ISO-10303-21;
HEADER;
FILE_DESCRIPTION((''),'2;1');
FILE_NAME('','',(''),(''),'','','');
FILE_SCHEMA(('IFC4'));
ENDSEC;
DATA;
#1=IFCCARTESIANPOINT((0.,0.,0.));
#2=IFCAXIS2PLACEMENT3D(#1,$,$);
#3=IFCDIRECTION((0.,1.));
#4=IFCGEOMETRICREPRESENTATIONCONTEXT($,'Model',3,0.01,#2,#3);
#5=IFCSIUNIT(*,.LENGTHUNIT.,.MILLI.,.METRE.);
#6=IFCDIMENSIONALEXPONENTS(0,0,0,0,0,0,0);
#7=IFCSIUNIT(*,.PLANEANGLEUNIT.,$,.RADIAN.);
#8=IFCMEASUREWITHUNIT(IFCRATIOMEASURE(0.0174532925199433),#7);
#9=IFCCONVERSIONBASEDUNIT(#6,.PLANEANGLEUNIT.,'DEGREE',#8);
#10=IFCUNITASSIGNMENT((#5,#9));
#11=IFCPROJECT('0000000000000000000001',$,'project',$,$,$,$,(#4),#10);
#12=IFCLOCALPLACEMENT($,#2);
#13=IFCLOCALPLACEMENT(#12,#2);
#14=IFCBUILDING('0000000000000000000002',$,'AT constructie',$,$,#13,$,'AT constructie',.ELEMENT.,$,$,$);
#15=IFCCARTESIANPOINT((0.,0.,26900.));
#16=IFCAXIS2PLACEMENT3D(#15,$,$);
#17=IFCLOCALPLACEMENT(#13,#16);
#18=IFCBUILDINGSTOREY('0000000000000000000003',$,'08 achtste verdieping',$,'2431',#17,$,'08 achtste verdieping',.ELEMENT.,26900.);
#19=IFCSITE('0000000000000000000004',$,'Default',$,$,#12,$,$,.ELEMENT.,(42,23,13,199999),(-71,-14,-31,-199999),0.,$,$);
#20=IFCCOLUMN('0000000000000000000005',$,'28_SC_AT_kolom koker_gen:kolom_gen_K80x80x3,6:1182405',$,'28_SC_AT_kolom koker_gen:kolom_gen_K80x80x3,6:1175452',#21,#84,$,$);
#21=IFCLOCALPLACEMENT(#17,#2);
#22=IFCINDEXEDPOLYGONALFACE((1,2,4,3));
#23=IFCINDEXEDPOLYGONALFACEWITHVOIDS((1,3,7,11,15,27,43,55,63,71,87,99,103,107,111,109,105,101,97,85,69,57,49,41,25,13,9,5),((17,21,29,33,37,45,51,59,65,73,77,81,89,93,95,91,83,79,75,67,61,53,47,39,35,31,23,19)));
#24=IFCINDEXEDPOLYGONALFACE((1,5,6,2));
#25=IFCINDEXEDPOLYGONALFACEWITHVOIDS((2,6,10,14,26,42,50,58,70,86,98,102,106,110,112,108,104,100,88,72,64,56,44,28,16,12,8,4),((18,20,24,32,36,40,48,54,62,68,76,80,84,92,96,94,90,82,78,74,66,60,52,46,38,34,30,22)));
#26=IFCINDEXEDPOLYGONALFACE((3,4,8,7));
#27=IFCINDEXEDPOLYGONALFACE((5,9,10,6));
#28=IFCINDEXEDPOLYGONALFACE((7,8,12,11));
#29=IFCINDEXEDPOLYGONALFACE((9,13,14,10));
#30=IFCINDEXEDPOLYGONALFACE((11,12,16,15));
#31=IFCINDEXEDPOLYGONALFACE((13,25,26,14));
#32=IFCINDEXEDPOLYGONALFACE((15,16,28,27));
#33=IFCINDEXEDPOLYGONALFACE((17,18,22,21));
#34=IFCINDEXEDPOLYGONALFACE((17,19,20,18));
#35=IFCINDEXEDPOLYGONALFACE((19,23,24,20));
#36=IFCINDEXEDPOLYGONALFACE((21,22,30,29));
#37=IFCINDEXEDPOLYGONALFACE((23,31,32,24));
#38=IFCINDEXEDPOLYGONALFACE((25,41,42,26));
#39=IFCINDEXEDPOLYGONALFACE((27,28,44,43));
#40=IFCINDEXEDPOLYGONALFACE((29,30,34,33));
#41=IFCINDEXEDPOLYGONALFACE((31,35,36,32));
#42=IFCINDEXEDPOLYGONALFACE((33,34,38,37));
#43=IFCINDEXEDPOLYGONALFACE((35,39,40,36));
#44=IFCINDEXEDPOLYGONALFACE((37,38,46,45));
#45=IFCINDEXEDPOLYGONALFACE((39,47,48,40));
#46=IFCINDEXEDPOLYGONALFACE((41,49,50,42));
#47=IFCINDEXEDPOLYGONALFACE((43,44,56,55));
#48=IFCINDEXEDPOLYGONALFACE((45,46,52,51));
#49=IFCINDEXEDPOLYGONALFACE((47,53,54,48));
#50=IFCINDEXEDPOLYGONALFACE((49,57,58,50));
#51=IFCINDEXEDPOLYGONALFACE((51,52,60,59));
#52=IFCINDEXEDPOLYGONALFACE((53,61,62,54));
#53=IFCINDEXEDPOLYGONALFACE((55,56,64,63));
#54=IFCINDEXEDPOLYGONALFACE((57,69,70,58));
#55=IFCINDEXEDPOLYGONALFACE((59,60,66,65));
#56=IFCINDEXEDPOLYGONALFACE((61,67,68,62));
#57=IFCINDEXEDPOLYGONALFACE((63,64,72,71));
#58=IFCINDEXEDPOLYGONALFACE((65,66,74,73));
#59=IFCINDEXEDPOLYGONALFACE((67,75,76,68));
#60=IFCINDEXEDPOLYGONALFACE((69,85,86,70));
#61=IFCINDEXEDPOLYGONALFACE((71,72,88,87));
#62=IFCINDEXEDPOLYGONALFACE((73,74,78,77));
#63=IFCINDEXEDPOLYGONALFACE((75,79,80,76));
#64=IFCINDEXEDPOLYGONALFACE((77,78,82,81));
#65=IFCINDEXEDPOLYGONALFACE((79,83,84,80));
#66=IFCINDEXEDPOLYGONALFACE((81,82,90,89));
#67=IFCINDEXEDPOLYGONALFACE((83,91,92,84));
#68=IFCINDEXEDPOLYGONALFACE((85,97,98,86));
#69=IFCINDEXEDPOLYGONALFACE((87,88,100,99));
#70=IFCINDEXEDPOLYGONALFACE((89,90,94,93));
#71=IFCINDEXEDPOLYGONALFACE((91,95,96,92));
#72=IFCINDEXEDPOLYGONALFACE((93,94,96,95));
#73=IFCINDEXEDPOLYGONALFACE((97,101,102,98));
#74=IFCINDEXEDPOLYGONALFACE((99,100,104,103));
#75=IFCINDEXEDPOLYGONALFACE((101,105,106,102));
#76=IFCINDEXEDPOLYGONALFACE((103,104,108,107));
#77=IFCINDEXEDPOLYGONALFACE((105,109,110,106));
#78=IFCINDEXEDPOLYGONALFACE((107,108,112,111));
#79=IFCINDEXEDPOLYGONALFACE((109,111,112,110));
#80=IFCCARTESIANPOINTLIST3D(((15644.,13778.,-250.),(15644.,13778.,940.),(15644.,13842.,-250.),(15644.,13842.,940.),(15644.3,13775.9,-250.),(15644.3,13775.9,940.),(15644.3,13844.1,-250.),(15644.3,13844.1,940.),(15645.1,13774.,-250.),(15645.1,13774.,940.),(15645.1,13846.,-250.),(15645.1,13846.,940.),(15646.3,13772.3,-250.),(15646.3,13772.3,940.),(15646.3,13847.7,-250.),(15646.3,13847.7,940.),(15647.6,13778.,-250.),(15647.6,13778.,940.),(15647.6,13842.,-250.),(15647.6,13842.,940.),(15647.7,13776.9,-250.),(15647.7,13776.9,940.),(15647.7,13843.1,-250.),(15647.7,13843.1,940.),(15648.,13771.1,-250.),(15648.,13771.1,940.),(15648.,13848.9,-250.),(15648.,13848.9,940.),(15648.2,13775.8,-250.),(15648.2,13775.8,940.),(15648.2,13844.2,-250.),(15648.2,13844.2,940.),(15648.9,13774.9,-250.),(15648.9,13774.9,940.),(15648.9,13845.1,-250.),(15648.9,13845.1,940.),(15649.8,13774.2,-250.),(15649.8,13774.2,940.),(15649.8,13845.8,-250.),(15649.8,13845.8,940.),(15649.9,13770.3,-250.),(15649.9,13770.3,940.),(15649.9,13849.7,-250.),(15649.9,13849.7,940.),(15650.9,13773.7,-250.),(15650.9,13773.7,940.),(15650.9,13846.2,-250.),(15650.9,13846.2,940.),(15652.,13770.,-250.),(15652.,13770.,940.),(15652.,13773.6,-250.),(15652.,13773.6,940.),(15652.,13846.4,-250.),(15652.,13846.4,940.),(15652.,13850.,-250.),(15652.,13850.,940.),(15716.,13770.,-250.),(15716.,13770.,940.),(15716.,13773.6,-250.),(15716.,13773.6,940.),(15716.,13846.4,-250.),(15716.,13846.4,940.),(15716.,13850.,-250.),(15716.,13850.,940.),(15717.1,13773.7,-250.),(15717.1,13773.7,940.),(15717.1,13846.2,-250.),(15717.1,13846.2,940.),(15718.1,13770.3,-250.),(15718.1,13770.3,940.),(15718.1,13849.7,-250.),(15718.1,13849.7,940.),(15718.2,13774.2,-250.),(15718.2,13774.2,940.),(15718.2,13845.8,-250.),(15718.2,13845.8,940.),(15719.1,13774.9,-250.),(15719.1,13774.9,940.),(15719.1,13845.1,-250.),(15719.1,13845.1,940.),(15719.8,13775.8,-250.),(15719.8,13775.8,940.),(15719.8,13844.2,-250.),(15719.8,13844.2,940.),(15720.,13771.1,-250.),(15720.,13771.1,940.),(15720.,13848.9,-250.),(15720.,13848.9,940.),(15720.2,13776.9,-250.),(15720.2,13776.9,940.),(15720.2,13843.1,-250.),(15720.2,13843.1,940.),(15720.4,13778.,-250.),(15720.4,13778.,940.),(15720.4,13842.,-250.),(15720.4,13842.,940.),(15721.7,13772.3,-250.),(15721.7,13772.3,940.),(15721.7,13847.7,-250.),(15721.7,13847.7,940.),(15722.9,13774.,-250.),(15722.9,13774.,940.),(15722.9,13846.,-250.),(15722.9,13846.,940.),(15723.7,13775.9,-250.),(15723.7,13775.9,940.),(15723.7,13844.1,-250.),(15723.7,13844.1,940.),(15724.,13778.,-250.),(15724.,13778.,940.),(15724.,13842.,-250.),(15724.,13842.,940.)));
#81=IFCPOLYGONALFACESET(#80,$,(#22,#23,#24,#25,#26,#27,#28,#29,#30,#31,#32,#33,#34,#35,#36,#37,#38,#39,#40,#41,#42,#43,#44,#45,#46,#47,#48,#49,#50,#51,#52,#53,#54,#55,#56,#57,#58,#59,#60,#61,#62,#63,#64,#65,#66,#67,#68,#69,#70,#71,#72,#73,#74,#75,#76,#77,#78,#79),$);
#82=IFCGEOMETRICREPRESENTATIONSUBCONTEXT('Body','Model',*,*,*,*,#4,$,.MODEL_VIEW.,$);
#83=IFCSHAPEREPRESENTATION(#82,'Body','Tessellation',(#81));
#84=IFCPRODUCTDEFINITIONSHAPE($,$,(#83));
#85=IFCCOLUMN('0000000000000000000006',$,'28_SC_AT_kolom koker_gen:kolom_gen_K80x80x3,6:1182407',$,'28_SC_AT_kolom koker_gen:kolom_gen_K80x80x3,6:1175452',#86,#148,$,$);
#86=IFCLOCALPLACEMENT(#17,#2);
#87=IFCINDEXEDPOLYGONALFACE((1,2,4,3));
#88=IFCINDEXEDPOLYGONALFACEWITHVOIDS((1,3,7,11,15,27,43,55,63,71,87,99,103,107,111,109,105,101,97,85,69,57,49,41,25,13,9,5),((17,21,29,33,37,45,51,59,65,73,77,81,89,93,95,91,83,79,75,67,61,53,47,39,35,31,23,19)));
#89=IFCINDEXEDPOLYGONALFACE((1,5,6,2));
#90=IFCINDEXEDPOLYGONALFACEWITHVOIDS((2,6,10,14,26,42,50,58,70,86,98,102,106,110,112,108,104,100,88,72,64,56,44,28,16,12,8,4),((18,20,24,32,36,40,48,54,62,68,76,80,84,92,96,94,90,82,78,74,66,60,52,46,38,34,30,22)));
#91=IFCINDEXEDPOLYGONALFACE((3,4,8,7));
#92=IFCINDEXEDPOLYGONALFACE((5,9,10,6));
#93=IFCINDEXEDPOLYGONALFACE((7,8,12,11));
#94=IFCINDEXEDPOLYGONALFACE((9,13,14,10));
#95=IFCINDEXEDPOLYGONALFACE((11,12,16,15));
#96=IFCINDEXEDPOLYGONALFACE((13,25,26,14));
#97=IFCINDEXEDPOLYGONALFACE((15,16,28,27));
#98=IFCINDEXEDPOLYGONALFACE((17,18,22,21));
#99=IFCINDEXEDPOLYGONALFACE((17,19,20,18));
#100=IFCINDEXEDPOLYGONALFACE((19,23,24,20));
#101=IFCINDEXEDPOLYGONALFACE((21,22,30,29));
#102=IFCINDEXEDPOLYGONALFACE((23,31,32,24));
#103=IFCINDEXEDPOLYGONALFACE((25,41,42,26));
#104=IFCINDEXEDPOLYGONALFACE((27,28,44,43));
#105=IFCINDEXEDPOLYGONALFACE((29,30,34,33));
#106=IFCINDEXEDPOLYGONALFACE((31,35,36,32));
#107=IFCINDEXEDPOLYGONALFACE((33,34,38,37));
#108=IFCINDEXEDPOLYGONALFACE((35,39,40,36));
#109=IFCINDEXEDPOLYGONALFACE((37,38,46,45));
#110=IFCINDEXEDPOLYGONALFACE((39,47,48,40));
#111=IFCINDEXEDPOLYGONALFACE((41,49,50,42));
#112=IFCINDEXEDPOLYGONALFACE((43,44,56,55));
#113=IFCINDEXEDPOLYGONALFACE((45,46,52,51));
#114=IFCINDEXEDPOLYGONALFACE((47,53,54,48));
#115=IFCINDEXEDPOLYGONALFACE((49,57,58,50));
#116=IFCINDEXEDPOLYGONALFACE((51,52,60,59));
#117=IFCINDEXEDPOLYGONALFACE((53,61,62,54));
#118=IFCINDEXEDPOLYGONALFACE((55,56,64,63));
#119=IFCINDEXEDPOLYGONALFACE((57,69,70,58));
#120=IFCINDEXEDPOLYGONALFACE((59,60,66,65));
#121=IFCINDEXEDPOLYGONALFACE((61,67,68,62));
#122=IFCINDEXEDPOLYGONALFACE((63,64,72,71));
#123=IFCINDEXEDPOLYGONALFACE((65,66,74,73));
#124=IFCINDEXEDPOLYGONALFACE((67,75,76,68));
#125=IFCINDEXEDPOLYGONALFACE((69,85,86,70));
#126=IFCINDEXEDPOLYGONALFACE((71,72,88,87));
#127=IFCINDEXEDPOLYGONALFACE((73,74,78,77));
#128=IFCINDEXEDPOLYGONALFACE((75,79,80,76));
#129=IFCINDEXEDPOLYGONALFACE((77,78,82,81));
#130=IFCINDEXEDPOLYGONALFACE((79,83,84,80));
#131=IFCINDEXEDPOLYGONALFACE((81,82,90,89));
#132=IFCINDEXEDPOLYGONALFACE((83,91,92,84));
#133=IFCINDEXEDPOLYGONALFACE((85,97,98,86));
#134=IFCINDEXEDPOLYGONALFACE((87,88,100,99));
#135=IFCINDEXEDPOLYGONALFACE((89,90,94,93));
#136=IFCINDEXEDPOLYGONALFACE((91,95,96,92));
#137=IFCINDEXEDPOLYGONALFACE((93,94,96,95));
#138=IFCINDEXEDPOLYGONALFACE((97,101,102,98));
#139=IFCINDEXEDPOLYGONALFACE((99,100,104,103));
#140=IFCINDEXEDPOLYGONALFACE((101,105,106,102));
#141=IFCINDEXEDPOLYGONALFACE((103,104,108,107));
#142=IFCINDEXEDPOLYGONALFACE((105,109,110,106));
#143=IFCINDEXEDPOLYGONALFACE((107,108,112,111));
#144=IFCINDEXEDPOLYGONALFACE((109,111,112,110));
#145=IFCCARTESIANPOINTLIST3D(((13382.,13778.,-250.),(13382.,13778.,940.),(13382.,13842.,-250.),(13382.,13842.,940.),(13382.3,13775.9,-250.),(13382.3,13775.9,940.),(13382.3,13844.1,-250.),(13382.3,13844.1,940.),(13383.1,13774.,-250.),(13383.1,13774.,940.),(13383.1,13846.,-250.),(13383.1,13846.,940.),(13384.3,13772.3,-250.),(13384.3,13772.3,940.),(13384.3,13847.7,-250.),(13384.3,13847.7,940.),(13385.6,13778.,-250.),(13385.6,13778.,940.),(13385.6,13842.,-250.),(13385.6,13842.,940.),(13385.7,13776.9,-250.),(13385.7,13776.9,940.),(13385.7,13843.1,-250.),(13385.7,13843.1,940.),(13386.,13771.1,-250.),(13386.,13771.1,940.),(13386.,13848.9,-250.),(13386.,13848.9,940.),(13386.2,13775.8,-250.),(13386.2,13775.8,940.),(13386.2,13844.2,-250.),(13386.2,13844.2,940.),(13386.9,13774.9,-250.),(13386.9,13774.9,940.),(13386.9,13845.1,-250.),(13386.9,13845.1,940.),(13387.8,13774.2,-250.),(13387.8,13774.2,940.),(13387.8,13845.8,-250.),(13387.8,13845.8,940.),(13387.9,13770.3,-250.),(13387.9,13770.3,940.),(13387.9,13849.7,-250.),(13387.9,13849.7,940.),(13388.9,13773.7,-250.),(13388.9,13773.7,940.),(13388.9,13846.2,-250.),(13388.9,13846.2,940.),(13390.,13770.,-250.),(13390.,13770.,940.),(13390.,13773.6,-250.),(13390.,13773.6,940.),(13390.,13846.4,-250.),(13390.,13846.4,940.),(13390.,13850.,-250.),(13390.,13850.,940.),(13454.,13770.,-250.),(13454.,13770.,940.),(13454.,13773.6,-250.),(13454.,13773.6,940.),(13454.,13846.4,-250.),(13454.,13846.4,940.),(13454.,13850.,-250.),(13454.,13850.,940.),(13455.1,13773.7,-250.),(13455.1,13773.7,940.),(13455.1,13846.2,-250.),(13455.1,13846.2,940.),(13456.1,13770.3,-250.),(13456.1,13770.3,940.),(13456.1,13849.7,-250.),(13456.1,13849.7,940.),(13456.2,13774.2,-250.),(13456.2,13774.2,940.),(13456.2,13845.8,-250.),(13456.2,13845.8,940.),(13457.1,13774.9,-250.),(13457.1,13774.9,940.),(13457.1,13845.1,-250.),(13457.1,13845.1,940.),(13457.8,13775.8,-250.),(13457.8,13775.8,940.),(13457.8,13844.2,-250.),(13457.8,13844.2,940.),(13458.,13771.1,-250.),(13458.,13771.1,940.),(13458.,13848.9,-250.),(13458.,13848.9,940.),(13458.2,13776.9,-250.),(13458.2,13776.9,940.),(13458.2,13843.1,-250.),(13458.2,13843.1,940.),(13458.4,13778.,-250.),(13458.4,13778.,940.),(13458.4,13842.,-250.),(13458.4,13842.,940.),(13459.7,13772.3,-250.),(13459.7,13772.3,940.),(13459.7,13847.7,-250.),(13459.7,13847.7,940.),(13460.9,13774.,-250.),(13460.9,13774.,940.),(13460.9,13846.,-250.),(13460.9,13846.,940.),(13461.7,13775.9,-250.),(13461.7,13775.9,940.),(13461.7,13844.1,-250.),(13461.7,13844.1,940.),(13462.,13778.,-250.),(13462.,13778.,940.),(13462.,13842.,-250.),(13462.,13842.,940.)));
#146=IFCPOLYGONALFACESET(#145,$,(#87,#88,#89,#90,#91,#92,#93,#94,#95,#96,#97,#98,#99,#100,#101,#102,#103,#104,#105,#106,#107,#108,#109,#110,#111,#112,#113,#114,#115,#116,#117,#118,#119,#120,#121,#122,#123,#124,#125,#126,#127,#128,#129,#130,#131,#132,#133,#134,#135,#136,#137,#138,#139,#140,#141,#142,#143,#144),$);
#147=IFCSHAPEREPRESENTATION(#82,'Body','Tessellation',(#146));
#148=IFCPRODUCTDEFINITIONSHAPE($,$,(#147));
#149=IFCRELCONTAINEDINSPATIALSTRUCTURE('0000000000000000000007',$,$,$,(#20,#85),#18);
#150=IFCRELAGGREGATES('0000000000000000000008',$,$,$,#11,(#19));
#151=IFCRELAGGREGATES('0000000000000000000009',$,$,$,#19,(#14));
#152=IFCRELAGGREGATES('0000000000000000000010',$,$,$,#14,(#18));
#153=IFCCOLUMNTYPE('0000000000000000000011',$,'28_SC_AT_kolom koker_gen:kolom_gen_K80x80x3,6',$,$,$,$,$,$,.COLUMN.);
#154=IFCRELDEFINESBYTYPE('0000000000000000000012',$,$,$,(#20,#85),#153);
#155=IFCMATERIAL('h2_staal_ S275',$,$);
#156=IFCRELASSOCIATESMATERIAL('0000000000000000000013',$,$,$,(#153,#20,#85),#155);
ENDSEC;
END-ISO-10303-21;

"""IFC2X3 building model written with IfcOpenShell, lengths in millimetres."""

from ifc_helpers import new_model, entity, si_unit, converted_unit, direction, frame, frame_2d, origin, place, context, subcontext, project, spatial, polyline, circle_curve, parameter, trimmed, segment, composite_curve, outline, extrude, source, transform, mapped, material, type_object, type_shapes, element, save


model = new_model("IFC2X3")

# Units and contexts
model_context = context("Model", 3, precision=0.01, world=origin(), true_north=direction((0.0, 1.0)))
body_context = subcontext(model_context, "Body", "Model", "MODEL_VIEW")
ifc_project = project(units=[si_unit("LENGTHUNIT", "METRE", prefix="MILLI"), converted_unit("PLANEANGLEUNIT", "DEGREE", entity("IfcRatioMeasure", 0.0174532925199433), si_unit("PLANEANGLEUNIT", "RADIAN"), dimensions=[0, 0, 0, 0, 0, 0, 0])], contexts=[model_context])

# Site, building, storey
site_placement = place(None, origin())
site = spatial("IfcSite", under=ifc_project, at=site_placement, Name="Default", CompositionType="ELEMENT", RefLatitude=(42, 23, 13, 199999), RefLongitude=(-71, -14, -31, -199999), RefElevation=0.0)
building_placement = place(site_placement, origin())
building = spatial("IfcBuilding", under=site, at=building_placement, Name="AT constructie", LongName="AT constructie", CompositionType="ELEMENT")
storey_placement = place(building_placement, frame((0.0, 0.0, 26900.0)))
storey = spatial("IfcBuildingStorey", under=building, at=storey_placement, Name="08 achtste verdieping", ObjectType="2431", LongName="08 achtste verdieping", CompositionType="ELEMENT", Elevation=26900.0)

# Columns
ifc_material_1 = material(Name="h2_staal_ S275")
column_type_1 = type_object("IfcColumnType", Name="28_SC_AT_kolom koker_gen:kolom_gen_K80x80x3,6", PredefinedType="COLUMN", material=ifc_material_1)
shared_shape_1 = source(origin(), body_context, "Body", "SweptSolid", [
    extrude(outline(composite_curve([segment(trimmed(circle_curve(frame_2d((32.0, 32.0), x_axis=(1.0, 0.0)), 8.0), [parameter(360.0)], [parameter(90.0)], True, "PARAMETER"), True, "CONTINUOUS"), segment(polyline([(32.0, 40.0), (-32.0, 40.0)]), True, "CONTINUOUS"), segment(trimmed(circle_curve(frame_2d((-32.0, 32.0), x_axis=(1.0, 0.0)), 8.0), [parameter(90.0)], [parameter(180.0)], True, "PARAMETER"), True, "CONTINUOUS"), segment(polyline([(-40.0, 32.0), (-40.0, -32.0)]), True, "CONTINUOUS"), segment(trimmed(circle_curve(frame_2d((-32.0, -32.0), x_axis=(1.0, 0.0)), 8.0), [parameter(180.0)], [parameter(270.0)], True, "PARAMETER"), True, "CONTINUOUS"), segment(polyline([(-32.0, -40.0), (32.0, -40.0)]), True, "CONTINUOUS"), segment(trimmed(circle_curve(frame_2d((32.0, -32.0), x_axis=(1.0, 0.0)), 8.0), [parameter(270.0)], [parameter(0.0)], True, "PARAMETER"), True, "CONTINUOUS"), segment(polyline([(40.0, -32.0), (40.0, 32.0)]), True, "CONTINUOUS")], self_intersect=False), holes=[composite_curve([segment(polyline([(-32.0, 36.4), (32.0, 36.4)]), True, "CONTINUOUS"), segment(trimmed(circle_curve(frame_2d((32.0, 32.0), x_axis=(1.0, 0.0)), 4.4), [parameter(360.0)], [parameter(90.0)], True, "PARAMETER"), False, "CONTINUOUS"), segment(polyline([(36.4, 32.0), (36.4, -32.0)]), True, "CONTINUOUS"), segment(trimmed(circle_curve(frame_2d((32.0, -32.0), x_axis=(1.0, 0.0)), 4.4), [parameter(270.0)], [parameter(360.0)], True, "PARAMETER"), False, "CONTINUOUS"), segment(polyline([(32.0, -36.4), (-32.0, -36.4)]), True, "CONTINUOUS"), segment(trimmed(circle_curve(frame_2d((-32.0, -32.0), x_axis=(1.0, 0.0)), 4.4), [parameter(180.0)], [parameter(270.0)], True, "PARAMETER"), False, "CONTINUOUS"), segment(polyline([(-36.4, -32.0), (-36.4, 32.0)]), True, "CONTINUOUS"), segment(trimmed(circle_curve(frame_2d((-32.0, 32.0), x_axis=(1.0, 0.0)), 4.4), [parameter(90.0)], [parameter(180.0)], True, "PARAMETER"), False, "CONTINUOUS")], self_intersect=False)]), frame((0.0, 0.0, 26650.0), z_axis=(0.0, 0.0, 1.0), x_axis=(-1.0, 0.0, 0.0)), (0.0, 0.0, 1.0), 1190.0),
])
type_shapes(column_type_1, [shared_shape_1])
for number, where, name in (
    (1, (15684.0, 13810.0, -26900.0), "28_SC_AT_kolom koker_gen:kolom_gen_K80x80x3,6:1182405"),
    (2, (13422.0, 13810.0, -26900.0), "28_SC_AT_kolom koker_gen:kolom_gen_K80x80x3,6:1182407"),
):
    element("IfcColumn", number, at=place(storey_placement, frame(where)), inside=storey, type_object=column_type_1, material=ifc_material_1, Name=name, ObjectType="28_SC_AT_kolom koker_gen:kolom_gen_K80x80x3,6:1175452", context=body_context, shape_type="MappedRepresentation", body=[
        mapped(shared_shape_1, transform((0.0, 0.0, 0.0), scale=1.0)),
    ])

save(model, "model.ifc")
